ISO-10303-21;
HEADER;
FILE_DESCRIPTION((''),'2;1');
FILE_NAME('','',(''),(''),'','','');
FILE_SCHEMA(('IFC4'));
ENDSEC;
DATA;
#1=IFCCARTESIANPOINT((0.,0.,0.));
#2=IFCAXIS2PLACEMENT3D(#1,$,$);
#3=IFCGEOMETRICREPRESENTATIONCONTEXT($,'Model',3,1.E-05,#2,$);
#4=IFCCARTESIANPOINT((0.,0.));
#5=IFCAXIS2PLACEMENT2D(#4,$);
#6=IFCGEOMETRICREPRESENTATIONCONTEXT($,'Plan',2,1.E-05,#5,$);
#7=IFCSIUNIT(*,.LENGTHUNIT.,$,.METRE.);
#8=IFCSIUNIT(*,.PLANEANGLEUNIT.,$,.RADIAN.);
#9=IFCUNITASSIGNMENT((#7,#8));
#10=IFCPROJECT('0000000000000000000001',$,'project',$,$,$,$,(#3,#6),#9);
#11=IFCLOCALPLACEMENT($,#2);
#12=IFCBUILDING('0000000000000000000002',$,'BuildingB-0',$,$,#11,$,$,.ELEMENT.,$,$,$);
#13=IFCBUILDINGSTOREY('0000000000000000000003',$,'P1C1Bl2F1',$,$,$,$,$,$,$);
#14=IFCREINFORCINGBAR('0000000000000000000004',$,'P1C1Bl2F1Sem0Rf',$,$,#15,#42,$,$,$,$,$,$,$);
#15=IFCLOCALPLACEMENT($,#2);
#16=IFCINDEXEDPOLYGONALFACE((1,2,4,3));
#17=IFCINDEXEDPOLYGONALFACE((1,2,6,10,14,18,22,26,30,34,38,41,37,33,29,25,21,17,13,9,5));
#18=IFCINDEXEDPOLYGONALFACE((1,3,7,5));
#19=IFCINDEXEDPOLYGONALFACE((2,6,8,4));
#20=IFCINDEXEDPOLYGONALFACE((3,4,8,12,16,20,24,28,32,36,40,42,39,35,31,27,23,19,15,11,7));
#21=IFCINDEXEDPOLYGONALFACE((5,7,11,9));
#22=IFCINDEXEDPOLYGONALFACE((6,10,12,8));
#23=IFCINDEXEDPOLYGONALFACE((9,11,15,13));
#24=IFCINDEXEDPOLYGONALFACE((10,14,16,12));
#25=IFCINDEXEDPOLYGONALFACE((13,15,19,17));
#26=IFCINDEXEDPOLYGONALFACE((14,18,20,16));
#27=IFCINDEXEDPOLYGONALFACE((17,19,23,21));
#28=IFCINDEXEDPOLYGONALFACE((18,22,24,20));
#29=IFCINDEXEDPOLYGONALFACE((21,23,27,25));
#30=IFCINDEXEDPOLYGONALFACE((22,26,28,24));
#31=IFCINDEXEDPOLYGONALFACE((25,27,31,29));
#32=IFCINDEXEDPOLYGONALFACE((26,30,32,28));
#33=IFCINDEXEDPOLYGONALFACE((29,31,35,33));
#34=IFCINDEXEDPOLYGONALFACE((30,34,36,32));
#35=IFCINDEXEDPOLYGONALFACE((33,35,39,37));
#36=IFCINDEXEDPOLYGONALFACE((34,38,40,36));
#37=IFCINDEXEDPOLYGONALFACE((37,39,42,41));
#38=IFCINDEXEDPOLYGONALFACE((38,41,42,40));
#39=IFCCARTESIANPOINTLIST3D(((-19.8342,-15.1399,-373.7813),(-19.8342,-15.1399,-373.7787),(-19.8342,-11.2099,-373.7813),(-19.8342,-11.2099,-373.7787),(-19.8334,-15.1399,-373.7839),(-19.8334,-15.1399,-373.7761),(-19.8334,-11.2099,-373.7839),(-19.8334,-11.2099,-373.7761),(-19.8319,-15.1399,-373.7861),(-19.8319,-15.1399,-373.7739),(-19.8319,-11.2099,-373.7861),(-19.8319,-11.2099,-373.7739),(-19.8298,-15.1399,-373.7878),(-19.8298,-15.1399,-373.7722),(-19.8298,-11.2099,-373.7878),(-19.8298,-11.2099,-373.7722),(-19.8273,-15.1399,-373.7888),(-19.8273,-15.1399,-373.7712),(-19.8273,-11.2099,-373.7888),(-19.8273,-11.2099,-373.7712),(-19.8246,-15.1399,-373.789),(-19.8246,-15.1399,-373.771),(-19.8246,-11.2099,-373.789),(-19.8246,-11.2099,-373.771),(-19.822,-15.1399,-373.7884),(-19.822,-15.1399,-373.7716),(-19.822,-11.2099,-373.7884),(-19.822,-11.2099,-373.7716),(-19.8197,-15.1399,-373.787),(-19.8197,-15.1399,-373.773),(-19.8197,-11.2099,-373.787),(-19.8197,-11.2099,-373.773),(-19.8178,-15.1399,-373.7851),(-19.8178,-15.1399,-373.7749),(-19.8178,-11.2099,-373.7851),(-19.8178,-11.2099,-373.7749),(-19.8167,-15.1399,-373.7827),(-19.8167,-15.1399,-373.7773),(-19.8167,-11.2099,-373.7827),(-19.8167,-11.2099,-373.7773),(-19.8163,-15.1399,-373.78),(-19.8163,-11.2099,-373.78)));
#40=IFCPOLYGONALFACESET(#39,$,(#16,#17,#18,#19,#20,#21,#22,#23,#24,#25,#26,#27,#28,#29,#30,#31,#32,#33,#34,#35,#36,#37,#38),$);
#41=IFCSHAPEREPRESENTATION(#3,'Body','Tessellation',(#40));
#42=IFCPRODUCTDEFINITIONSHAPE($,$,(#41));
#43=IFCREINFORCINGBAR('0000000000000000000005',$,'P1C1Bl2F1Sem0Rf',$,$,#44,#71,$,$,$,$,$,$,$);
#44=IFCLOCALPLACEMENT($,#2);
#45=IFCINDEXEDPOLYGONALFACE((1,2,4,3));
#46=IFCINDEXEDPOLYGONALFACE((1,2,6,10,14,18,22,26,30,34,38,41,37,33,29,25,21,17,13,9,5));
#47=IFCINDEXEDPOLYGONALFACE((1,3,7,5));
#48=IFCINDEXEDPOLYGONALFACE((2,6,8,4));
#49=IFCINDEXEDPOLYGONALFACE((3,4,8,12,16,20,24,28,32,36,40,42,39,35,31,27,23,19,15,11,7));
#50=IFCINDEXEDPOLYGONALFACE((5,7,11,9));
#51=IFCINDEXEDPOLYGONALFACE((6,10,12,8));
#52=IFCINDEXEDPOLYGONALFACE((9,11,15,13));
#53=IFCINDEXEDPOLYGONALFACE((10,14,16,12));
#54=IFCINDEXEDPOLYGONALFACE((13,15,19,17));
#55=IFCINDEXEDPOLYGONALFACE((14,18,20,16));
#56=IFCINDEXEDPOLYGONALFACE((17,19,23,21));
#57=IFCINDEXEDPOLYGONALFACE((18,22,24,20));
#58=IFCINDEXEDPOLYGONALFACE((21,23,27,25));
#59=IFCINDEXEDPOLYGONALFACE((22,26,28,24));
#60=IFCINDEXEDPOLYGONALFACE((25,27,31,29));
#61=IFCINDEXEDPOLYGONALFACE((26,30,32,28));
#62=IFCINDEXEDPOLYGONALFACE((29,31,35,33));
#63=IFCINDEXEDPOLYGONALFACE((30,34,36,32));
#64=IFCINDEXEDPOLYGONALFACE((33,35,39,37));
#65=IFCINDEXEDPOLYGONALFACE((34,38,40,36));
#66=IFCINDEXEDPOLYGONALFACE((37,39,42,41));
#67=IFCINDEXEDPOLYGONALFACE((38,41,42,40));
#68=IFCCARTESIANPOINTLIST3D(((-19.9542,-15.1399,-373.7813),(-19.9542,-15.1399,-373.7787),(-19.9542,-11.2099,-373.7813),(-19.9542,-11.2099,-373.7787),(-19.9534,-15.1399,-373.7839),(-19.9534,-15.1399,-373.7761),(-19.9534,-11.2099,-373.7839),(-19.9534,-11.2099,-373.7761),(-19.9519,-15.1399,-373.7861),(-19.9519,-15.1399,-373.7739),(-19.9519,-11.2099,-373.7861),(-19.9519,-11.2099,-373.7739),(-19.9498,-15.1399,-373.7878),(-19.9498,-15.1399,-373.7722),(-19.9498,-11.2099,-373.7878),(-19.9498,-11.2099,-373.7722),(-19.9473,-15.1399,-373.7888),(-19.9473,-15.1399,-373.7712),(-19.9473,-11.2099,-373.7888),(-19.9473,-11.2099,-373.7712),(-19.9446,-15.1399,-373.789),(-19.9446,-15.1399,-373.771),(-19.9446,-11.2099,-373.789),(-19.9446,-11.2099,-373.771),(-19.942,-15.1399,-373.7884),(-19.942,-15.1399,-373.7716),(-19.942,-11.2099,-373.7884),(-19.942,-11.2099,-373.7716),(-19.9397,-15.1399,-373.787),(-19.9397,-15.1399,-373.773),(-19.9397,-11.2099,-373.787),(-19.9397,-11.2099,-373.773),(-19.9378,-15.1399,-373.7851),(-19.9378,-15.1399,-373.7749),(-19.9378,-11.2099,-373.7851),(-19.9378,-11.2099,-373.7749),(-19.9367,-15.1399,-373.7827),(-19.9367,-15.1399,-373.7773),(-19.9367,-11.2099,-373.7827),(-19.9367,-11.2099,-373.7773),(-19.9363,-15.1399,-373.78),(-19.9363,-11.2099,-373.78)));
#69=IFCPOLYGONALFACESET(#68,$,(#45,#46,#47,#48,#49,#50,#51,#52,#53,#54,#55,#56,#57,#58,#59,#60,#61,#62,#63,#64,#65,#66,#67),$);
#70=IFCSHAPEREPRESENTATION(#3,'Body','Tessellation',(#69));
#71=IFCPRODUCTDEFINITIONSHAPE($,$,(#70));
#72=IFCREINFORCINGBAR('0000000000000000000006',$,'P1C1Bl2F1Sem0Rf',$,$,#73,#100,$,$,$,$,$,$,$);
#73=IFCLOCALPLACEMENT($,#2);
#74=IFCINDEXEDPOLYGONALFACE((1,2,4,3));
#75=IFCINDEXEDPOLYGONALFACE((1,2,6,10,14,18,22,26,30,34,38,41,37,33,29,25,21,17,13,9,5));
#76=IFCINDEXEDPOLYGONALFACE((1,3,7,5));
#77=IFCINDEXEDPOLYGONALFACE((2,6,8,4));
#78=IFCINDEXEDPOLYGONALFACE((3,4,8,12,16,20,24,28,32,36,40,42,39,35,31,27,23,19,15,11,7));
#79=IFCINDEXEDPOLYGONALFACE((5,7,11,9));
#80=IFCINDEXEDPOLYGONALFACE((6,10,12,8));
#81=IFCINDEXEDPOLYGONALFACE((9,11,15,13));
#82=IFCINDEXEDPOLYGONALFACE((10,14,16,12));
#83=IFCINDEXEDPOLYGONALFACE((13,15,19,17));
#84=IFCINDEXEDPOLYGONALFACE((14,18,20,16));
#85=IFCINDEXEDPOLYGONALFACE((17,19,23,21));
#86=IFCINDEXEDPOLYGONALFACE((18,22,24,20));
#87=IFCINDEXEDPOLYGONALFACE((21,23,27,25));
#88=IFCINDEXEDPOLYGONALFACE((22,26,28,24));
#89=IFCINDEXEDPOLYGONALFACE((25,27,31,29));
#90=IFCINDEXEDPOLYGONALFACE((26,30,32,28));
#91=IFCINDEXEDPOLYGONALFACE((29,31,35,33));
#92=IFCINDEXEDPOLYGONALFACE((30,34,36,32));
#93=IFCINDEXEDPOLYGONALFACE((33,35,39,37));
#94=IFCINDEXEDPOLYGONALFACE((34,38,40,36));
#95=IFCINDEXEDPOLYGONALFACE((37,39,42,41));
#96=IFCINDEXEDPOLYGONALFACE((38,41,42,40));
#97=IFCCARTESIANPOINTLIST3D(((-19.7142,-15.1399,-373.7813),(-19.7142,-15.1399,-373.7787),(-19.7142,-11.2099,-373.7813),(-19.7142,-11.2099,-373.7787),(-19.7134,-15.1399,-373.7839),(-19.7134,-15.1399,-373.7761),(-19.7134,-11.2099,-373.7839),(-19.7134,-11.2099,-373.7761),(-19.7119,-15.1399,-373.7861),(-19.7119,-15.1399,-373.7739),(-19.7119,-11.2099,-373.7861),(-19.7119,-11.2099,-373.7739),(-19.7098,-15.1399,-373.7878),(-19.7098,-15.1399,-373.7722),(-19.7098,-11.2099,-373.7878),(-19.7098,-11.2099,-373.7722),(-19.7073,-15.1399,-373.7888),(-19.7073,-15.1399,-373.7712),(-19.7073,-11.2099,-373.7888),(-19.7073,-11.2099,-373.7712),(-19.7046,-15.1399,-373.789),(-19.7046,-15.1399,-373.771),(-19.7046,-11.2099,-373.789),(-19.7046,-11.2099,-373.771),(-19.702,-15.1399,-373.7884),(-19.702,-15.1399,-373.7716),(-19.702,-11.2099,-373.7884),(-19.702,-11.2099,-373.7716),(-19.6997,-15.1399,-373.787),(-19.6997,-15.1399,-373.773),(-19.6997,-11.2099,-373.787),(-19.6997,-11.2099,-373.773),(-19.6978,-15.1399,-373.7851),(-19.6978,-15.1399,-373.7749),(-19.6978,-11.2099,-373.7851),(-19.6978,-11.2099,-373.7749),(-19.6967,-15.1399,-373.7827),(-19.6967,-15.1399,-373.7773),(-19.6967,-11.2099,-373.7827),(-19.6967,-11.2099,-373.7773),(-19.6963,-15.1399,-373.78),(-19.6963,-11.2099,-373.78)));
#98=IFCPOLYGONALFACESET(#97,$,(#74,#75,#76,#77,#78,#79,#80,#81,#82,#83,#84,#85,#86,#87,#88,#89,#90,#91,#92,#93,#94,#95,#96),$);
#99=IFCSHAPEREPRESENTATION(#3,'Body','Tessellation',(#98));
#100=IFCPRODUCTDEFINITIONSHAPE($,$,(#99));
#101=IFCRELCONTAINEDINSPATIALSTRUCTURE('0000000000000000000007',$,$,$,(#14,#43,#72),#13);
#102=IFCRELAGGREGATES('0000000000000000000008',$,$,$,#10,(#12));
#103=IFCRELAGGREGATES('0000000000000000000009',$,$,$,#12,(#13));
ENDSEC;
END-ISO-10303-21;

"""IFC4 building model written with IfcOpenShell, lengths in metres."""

from ifc_helpers import new_model, entity, si_unit, origin, origin_2d, place, context, project, spatial, element, save


model = new_model("IFC4")

# Units and contexts
model_context = context("Model", 3, precision=1e-05, world=origin())
plan_context = context("Plan", 2, precision=1e-05, world=origin_2d())
ifc_project = project(units=[si_unit("LENGTHUNIT", "METRE"), si_unit("PLANEANGLEUNIT", "RADIAN")], contexts=[model_context, plan_context])

# Building, storey
building_placement = place(None, origin())
building = spatial("IfcBuilding", under=ifc_project, at=building_placement, Name="BuildingB-0", CompositionType="ELEMENT")
storey = spatial("IfcBuildingStorey", under=building, Name="P1C1Bl2F1")

# Reinforcing bars
element("IfcReinforcingBar", 1, inside=storey, Name="P1C1Bl2F1Sem0Rf", context=model_context, shape_type="SweptSolid", body=[
    entity("IfcSurfaceCurveSweptAreaSolid", entity("IfcCircleProfileDef", "AREA", None, None, 0.009), None, entity("IfcPolyline", [entity("IfcCartesianPoint", [19.8253, 11.2099, 373.78]), entity("IfcCartesianPoint", [19.8253, 15.1399, 373.78])]), None, None, entity("IfcPlane", entity("IfcAxis2Placement3D", entity("IfcCartesianPoint", [19.8253, 11.2099, 373.78]), entity("IfcDirection", [0.0, 0.0, 1.0]), entity("IfcDirection", [1.0, 0.0, 0.0])))),
])
element("IfcReinforcingBar", 2, inside=storey, Name="P1C1Bl2F1Sem0Rf", context=model_context, shape_type="SweptSolid", body=[
    entity("IfcSurfaceCurveSweptAreaSolid", entity("IfcCircleProfileDef", "AREA", None, None, 0.009), None, entity("IfcPolyline", [entity("IfcCartesianPoint", [19.9453, 11.2099, 373.78]), entity("IfcCartesianPoint", [19.9453, 15.1399, 373.78])]), None, None, entity("IfcPlane", entity("IfcAxis2Placement3D", entity("IfcCartesianPoint", [19.9453, 11.2099, 373.78]), entity("IfcDirection", [0.0, 0.0, 1.0]), entity("IfcDirection", [1.0, 0.0, 0.0])))),
])
element("IfcReinforcingBar", 3, inside=storey, Name="P1C1Bl2F1Sem0Rf", context=model_context, shape_type="SweptSolid", body=[
    entity("IfcSurfaceCurveSweptAreaSolid", entity("IfcCircleProfileDef", "AREA", None, None, 0.009), None, entity("IfcPolyline", [entity("IfcCartesianPoint", [19.7053, 11.2099, 373.78]), entity("IfcCartesianPoint", [19.7053, 15.1399, 373.78])]), None, None, entity("IfcPlane", entity("IfcAxis2Placement3D", entity("IfcCartesianPoint", [19.7053, 11.2099, 373.78]), entity("IfcDirection", [0.0, 0.0, 1.0]), entity("IfcDirection", [1.0, 0.0, 0.0])))),
])

save(model, "model.ifc")
